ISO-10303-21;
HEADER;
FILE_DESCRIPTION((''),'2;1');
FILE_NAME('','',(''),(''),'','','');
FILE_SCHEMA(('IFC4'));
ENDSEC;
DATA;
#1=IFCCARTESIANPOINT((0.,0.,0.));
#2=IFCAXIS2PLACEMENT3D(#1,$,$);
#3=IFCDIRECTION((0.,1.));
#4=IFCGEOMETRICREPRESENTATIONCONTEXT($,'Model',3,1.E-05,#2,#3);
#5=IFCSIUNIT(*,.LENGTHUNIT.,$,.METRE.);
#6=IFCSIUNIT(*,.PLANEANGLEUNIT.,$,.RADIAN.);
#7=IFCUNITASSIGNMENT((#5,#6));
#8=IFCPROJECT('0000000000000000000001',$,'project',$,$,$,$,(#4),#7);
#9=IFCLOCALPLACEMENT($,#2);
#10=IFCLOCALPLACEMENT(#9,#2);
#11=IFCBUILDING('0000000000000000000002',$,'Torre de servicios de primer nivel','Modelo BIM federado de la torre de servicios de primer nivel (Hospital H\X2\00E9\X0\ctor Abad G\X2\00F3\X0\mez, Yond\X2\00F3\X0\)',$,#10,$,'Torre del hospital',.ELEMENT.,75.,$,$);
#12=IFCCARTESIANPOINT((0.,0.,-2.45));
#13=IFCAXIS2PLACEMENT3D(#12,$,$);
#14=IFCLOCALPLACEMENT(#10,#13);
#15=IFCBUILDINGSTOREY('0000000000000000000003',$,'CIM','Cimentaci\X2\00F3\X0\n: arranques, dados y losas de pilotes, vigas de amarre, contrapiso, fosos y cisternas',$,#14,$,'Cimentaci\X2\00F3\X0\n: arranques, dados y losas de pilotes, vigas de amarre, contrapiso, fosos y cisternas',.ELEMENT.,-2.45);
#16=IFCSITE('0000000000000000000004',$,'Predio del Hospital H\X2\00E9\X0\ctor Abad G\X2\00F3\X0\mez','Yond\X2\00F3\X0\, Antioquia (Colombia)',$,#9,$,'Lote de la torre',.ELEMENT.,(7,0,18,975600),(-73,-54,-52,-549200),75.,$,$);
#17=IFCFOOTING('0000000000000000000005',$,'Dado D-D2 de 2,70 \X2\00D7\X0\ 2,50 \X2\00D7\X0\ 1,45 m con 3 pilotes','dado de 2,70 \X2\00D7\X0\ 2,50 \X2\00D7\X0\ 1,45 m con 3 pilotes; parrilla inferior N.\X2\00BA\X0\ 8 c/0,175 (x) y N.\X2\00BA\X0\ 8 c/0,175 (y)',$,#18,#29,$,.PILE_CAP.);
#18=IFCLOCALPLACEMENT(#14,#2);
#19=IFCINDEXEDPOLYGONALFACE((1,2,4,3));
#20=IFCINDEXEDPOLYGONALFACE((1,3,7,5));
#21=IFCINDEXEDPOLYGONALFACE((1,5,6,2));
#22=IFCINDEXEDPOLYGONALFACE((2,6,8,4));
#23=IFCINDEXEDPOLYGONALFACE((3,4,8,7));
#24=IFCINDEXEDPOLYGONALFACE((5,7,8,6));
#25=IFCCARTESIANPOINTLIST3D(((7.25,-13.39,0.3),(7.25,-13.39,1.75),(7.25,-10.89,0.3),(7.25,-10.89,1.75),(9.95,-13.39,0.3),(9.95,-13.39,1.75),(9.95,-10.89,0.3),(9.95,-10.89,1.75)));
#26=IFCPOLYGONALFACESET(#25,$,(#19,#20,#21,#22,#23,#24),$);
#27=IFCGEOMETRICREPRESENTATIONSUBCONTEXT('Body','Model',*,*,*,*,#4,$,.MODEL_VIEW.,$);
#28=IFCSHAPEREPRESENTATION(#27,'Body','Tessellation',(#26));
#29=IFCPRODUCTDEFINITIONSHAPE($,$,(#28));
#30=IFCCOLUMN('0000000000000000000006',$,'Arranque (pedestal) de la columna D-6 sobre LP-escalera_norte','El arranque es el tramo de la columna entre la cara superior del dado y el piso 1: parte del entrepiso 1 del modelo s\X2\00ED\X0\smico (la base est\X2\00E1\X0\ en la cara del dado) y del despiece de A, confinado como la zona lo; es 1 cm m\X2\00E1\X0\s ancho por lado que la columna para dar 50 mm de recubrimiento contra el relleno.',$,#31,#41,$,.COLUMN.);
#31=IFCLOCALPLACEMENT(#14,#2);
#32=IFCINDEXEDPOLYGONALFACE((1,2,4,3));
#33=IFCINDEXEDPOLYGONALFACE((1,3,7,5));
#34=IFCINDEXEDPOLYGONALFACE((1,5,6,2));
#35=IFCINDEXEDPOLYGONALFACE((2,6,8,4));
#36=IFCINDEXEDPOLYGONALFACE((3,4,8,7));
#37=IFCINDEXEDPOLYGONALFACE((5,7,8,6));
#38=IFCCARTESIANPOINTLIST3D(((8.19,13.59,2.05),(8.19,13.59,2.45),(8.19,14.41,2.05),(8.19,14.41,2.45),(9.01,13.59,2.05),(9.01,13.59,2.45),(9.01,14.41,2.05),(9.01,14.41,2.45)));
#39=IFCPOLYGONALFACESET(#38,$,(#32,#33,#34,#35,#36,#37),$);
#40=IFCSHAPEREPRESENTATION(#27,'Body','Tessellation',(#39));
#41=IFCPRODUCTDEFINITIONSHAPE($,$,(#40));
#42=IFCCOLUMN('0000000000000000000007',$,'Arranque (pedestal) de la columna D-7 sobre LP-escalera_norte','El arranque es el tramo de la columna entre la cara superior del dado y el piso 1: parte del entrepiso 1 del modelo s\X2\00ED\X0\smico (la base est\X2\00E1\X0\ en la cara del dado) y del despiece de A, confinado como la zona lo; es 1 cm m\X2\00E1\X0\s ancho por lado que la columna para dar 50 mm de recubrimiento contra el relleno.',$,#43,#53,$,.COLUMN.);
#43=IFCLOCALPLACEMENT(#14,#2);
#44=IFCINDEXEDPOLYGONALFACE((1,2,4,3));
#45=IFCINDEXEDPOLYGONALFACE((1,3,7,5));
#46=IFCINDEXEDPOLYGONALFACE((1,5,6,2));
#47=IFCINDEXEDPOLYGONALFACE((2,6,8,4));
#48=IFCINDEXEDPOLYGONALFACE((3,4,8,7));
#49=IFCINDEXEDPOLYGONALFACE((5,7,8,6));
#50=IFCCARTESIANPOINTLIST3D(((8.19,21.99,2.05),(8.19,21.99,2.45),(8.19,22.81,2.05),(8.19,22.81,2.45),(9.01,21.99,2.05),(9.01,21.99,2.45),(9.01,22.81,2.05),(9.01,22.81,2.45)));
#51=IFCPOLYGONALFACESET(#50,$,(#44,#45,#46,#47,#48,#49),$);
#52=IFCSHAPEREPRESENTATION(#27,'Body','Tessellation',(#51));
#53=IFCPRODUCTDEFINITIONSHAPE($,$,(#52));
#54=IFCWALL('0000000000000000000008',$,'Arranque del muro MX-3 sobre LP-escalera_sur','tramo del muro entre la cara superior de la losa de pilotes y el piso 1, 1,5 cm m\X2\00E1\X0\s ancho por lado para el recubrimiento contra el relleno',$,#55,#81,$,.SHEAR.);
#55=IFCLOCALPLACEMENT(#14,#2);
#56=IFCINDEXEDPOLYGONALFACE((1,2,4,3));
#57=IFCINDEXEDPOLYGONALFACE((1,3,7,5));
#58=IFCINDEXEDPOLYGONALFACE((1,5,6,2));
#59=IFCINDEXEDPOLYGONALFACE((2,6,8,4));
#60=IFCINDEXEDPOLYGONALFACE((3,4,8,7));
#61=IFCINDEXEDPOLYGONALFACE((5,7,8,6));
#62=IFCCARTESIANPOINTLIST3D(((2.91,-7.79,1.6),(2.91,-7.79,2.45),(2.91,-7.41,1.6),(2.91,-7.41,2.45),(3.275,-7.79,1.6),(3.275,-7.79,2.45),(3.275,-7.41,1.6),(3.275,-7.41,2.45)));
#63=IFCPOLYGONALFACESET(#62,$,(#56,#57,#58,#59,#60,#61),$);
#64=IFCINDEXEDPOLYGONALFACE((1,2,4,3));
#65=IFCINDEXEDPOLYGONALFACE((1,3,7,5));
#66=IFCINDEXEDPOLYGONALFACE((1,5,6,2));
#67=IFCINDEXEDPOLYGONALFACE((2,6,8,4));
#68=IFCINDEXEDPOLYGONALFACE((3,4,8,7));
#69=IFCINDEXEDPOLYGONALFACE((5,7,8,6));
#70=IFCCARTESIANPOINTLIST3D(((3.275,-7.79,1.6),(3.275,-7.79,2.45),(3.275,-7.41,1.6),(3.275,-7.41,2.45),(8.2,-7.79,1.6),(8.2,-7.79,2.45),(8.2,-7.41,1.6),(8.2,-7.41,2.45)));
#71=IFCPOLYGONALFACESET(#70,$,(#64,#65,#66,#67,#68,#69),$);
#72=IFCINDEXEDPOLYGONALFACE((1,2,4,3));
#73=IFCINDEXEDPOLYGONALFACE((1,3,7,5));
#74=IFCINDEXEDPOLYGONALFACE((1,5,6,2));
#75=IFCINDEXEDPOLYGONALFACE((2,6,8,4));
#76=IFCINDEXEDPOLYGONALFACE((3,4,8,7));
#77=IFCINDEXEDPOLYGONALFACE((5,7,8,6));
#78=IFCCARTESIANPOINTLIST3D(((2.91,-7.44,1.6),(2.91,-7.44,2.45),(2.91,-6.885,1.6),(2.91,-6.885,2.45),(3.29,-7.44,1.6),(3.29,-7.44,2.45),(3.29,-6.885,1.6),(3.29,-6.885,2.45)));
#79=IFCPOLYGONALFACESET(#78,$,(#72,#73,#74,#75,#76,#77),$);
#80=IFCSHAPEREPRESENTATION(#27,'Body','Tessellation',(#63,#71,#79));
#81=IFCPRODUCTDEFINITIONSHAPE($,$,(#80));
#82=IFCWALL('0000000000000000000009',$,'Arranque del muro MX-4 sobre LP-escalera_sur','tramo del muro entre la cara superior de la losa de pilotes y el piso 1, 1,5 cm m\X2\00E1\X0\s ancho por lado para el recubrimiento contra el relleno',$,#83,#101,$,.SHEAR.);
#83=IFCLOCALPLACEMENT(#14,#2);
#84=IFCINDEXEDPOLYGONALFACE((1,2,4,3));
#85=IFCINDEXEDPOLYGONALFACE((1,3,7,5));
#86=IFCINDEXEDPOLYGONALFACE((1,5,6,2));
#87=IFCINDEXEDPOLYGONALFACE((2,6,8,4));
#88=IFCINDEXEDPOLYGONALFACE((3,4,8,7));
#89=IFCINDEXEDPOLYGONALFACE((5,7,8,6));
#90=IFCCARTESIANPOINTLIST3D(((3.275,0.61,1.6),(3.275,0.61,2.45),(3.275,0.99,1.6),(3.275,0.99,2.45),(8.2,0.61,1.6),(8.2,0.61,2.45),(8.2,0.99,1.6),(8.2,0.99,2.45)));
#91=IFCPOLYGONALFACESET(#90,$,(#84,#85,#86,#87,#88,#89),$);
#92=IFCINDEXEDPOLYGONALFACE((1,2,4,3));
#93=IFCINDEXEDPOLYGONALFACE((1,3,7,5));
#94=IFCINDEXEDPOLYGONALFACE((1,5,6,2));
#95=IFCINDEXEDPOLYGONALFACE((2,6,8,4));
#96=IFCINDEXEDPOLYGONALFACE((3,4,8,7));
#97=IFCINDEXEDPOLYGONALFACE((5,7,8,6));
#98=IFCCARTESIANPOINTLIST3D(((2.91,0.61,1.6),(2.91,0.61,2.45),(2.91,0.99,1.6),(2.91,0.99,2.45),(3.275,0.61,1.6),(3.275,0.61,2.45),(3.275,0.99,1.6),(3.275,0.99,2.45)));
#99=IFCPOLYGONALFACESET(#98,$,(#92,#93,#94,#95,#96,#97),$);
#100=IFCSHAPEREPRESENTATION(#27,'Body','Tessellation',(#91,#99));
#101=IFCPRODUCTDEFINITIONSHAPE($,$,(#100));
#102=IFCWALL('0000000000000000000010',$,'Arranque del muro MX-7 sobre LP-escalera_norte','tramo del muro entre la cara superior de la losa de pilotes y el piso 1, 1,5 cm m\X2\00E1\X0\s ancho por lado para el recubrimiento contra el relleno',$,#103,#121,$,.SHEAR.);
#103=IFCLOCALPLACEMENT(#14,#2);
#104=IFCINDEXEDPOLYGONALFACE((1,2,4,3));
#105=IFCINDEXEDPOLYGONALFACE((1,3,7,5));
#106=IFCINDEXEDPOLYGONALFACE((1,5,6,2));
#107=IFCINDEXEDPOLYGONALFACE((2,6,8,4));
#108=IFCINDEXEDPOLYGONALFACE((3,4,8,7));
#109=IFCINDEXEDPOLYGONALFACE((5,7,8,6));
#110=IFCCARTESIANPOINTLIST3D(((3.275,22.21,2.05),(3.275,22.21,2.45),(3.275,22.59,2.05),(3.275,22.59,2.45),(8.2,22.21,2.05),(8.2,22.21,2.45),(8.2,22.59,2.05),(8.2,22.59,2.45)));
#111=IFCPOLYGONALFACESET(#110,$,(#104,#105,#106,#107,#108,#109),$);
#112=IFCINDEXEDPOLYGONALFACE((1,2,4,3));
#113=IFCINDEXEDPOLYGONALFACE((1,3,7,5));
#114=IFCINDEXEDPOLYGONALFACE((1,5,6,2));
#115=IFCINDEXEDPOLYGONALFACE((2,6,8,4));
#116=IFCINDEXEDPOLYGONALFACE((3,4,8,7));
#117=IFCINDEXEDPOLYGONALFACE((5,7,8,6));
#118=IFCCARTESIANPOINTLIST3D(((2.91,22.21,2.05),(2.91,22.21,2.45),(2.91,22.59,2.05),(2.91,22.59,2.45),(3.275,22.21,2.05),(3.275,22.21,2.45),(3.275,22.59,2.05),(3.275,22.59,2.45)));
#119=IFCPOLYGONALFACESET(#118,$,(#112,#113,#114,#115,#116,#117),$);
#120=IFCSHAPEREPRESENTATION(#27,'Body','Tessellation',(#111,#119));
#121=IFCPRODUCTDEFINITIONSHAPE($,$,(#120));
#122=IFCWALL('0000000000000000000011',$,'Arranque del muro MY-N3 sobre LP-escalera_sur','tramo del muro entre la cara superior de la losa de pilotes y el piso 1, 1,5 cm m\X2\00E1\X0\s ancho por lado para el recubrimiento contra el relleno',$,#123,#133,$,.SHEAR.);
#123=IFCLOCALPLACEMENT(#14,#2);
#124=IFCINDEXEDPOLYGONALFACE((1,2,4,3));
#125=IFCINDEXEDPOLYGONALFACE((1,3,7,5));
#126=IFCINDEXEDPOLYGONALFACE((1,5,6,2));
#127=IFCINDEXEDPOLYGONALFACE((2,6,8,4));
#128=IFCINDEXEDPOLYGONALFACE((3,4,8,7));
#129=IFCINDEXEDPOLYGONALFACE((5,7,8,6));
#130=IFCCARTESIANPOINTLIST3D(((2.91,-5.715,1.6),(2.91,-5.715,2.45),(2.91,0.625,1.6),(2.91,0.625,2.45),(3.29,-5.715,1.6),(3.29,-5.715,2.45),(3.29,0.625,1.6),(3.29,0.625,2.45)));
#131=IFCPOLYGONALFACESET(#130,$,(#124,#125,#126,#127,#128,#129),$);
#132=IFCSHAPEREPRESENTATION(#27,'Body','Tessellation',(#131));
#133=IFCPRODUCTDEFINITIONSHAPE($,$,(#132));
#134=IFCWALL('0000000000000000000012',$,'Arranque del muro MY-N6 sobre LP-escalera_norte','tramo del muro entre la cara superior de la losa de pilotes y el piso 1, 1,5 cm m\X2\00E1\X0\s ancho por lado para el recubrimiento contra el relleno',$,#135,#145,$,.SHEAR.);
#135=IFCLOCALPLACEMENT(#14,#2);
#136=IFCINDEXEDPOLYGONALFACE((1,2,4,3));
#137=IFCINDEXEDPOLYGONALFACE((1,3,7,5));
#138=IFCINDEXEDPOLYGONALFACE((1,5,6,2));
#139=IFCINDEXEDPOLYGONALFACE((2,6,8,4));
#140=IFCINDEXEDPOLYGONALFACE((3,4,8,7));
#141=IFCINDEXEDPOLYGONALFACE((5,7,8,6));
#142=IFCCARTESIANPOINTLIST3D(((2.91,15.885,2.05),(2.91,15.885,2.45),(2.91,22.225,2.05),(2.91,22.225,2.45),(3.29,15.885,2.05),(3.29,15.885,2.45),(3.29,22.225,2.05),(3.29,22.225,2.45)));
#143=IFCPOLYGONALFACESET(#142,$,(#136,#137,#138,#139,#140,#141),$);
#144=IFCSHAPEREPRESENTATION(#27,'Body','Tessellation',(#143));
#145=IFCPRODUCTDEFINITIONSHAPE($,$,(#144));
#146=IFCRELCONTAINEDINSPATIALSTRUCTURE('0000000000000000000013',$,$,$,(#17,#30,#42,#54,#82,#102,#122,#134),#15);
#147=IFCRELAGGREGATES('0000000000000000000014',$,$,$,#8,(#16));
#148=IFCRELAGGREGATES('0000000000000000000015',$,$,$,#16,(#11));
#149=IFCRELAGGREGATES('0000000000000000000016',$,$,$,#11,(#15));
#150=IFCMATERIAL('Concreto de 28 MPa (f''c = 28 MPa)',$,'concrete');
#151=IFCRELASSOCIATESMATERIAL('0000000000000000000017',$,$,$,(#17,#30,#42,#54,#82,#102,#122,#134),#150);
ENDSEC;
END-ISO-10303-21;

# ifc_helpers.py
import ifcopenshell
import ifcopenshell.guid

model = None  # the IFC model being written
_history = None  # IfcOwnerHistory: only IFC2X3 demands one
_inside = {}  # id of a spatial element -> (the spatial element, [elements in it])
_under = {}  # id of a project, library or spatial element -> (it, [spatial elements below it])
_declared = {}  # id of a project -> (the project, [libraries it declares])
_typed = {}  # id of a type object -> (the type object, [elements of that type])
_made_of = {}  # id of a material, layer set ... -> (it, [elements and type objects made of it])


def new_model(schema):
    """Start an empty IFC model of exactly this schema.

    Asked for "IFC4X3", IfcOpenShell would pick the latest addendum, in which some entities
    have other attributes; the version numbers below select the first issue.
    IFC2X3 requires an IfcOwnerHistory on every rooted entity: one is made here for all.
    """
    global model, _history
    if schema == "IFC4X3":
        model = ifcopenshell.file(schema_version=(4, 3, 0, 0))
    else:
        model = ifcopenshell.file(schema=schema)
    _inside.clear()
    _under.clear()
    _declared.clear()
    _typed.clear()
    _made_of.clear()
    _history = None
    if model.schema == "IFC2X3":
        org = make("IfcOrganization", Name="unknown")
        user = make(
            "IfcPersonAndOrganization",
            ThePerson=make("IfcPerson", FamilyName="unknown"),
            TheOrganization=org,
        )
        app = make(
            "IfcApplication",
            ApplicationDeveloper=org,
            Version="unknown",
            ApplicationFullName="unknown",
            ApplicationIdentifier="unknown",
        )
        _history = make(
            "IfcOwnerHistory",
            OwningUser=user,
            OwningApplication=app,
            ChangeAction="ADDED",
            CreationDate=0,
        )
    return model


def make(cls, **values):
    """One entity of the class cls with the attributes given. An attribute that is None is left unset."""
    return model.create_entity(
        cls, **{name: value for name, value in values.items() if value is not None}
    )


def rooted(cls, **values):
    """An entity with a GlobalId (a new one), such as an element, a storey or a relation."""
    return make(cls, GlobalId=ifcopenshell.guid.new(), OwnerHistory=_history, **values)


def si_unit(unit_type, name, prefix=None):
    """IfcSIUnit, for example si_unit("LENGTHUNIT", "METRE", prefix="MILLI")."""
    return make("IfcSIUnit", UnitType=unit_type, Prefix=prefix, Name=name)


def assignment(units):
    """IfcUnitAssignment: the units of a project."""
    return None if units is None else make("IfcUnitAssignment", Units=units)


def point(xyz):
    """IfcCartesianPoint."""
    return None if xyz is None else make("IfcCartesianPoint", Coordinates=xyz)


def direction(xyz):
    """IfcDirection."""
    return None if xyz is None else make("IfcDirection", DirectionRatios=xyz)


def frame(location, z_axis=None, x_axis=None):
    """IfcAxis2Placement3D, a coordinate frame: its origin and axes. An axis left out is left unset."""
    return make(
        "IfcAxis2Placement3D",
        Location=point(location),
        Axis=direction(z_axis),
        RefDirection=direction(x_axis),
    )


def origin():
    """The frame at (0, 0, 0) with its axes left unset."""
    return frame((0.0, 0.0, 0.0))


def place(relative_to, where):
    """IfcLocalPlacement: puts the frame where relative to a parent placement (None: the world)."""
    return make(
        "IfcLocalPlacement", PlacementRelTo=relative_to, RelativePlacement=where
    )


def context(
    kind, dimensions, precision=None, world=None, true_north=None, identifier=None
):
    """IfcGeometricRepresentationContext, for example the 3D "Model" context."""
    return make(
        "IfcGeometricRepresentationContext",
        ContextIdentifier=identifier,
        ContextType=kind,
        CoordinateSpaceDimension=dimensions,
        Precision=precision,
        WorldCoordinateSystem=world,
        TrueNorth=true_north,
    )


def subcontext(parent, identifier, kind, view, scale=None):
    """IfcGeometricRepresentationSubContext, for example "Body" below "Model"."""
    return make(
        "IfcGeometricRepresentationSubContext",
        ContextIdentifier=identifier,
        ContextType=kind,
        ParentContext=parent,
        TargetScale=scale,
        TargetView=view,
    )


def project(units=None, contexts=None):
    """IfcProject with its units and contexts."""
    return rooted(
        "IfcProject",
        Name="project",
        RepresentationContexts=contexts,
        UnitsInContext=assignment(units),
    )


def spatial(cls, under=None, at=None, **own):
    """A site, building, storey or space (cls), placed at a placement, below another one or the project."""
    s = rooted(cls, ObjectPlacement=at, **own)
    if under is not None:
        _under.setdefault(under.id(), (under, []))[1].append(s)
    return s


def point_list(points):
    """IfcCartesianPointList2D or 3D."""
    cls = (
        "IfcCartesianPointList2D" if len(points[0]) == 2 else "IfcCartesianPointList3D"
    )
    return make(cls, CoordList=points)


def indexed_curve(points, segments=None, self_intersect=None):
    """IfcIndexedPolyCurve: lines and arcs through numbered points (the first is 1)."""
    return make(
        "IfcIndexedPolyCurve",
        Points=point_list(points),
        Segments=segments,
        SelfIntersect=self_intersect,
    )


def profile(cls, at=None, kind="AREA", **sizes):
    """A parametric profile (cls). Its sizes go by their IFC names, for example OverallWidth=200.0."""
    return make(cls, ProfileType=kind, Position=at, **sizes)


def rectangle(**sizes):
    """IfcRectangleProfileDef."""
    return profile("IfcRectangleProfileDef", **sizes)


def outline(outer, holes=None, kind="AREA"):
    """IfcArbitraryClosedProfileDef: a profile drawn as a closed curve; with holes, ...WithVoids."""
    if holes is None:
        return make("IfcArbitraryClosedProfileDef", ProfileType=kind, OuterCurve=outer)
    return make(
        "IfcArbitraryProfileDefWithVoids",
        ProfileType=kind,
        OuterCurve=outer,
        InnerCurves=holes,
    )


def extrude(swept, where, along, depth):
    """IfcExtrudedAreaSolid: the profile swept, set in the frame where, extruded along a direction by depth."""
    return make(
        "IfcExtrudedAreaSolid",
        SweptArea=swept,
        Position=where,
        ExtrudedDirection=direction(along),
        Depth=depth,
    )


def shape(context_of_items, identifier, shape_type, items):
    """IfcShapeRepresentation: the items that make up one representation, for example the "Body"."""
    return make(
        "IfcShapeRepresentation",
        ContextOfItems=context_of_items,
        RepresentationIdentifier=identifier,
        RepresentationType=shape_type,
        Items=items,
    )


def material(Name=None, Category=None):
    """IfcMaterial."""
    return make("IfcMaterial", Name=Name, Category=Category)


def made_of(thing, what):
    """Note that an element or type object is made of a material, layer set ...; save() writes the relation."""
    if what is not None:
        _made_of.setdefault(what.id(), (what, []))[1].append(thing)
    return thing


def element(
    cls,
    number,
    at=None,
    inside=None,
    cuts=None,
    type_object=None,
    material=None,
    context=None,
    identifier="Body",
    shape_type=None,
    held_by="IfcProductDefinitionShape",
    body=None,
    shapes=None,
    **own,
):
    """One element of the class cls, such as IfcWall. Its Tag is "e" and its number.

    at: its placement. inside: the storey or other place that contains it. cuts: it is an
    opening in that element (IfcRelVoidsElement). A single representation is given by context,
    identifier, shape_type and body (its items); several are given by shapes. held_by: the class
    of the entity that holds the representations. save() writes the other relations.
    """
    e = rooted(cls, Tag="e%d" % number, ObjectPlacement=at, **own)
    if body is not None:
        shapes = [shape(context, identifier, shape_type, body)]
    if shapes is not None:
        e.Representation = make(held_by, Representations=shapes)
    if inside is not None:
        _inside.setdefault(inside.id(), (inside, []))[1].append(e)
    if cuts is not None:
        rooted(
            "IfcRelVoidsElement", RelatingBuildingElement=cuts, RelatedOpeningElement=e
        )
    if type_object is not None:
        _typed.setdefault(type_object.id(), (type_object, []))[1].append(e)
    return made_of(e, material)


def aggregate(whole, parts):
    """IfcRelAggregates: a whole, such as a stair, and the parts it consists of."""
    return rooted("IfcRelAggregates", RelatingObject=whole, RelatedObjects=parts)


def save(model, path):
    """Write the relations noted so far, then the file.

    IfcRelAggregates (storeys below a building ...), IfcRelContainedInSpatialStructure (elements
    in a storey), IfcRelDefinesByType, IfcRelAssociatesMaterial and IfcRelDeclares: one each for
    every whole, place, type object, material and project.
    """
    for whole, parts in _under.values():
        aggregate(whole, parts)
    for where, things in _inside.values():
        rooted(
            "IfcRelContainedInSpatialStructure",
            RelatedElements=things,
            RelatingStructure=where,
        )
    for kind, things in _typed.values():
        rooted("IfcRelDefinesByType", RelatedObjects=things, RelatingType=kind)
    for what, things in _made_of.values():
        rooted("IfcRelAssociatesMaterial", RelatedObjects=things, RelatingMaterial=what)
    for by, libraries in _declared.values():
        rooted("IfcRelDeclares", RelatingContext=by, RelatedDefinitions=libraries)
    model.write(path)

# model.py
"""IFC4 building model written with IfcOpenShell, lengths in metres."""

from ifc_helpers import new_model, si_unit, direction, frame, origin, place, context, subcontext, project, spatial, indexed_curve, rectangle, outline, extrude, material, element, save


model = new_model("IFC4")

# Units and contexts
model_context = context("Model", 3, precision=1e-05, world=origin(), true_north=direction((0.0, 1.0)))
body_context = subcontext(model_context, "Body", "Model", "MODEL_VIEW")
ifc_project = project(units=[si_unit("LENGTHUNIT", "METRE"), si_unit("PLANEANGLEUNIT", "RADIAN")], contexts=[model_context])

# Site, building, storey
site_placement = place(None, origin())
site = spatial("IfcSite", under=ifc_project, at=site_placement, Name="Predio del Hospital Héctor Abad Gómez", Description="Yondó, Antioquia (Colombia)", LongName="Lote de la torre", CompositionType="ELEMENT", RefLatitude=(7, 0, 18, 975600), RefLongitude=(-73, -54, -52, -549200), RefElevation=75.0)
building_placement = place(site_placement, origin())
building = spatial("IfcBuilding", under=site, at=building_placement, Name="Torre de servicios de primer nivel", Description="Modelo BIM federado de la torre de servicios de primer nivel (Hospital Héctor Abad Gómez, Yondó)", LongName="Torre del hospital", CompositionType="ELEMENT", ElevationOfRefHeight=75.0)
placement = place(building_placement, frame((0.0, 0.0, -2.45)))
storey = spatial("IfcBuildingStorey", under=building, at=placement, Name="CIM", Description="Cimentación: arranques, dados y losas de pilotes, vigas de amarre, contrapiso, fosos y cisternas", LongName="Cimentación: arranques, dados y losas de pilotes, vigas de amarre, contrapiso, fosos y cisternas", CompositionType="ELEMENT", Elevation=-2.45)

# Footing
ifc_material = material(Name="Concreto de 28 MPa (f'c = 28 MPa)", Category="concrete")
element("IfcFooting", 1, at=placement, inside=storey, material=ifc_material, Name="Dado D-D2 de 2,70 × 2,50 × 1,45 m con 3 pilotes", Description="dado de 2,70 × 2,50 × 1,45 m con 3 pilotes; parrilla inferior N.º 8 c/0,175 (x) y N.º 8 c/0,175 (y)", PredefinedType="PILE_CAP", context=body_context, shape_type="SweptSolid", body=[
    extrude(rectangle(XDim=2.7, YDim=2.5), frame((8.6, -12.14, 0.3)), (0.0, 0.0, 1.0), 1.45),
])

# Columns
element("IfcColumn", 2, at=placement, inside=storey, material=ifc_material, Name="Arranque (pedestal) de la columna D-6 sobre LP-escalera_norte", Description="El arranque es el tramo de la columna entre la cara superior del dado y el piso 1: parte del entrepiso 1 del modelo sísmico (la base está en la cara del dado) y del despiece de A, confinado como la zona lo; es 1 cm más ancho por lado que la columna para dar 50 mm de recubrimiento contra el relleno.", PredefinedType="COLUMN", context=body_context, shape_type="SweptSolid", body=[
    extrude(rectangle(XDim=0.82, YDim=0.82), frame((8.6, 14.0, 2.05)), (0.0, 0.0, 1.0), 0.4),
])
element("IfcColumn", 3, at=placement, inside=storey, material=ifc_material, Name="Arranque (pedestal) de la columna D-7 sobre LP-escalera_norte", Description="El arranque es el tramo de la columna entre la cara superior del dado y el piso 1: parte del entrepiso 1 del modelo sísmico (la base está en la cara del dado) y del despiece de A, confinado como la zona lo; es 1 cm más ancho por lado que la columna para dar 50 mm de recubrimiento contra el relleno.", PredefinedType="COLUMN", context=body_context, shape_type="SweptSolid", body=[
    extrude(rectangle(XDim=0.82, YDim=0.82), frame((8.6, 22.4, 2.05)), (0.0, 0.0, 1.0), 0.4),
])

# Walls
element("IfcWall", 4, at=placement, inside=storey, material=ifc_material, Name="Arranque del muro MX-3 sobre LP-escalera_sur", Description="tramo del muro entre la cara superior de la losa de pilotes y el piso 1, 1,5 cm más ancho por lado para el recubrimiento contra el relleno", PredefinedType="SHEAR", context=body_context, shape_type="SweptSolid", body=[
    extrude(outline(indexed_curve([(2.91, -7.79), (3.275, -7.79), (3.275, -7.41), (2.91, -7.41), (2.91, -7.79)], self_intersect=False)), frame((0.0, 0.0, 1.6)), (0.0, 0.0, 1.0), 0.85),
    extrude(outline(indexed_curve([(3.275, -7.79), (8.2, -7.79), (8.2, -7.41), (3.275, -7.41), (3.275, -7.79)], self_intersect=False)), frame((0.0, 0.0, 1.6)), (0.0, 0.0, 1.0), 0.85),
    extrude(outline(indexed_curve([(2.91, -7.44), (3.29, -7.44), (3.29, -6.885), (2.91, -6.885), (2.91, -7.44)], self_intersect=False)), frame((0.0, 0.0, 1.6)), (0.0, 0.0, 1.0), 0.85),
])
element("IfcWall", 5, at=placement, inside=storey, material=ifc_material, Name="Arranque del muro MX-4 sobre LP-escalera_sur", Description="tramo del muro entre la cara superior de la losa de pilotes y el piso 1, 1,5 cm más ancho por lado para el recubrimiento contra el relleno", PredefinedType="SHEAR", context=body_context, shape_type="SweptSolid", body=[
    extrude(outline(indexed_curve([(3.275, 0.61), (8.2, 0.61), (8.2, 0.99), (3.275, 0.99), (3.275, 0.61)], self_intersect=False)), frame((0.0, 0.0, 1.6)), (0.0, 0.0, 1.0), 0.85),
    extrude(outline(indexed_curve([(2.91, 0.61), (3.275, 0.61), (3.275, 0.99), (2.91, 0.99), (2.91, 0.61)], self_intersect=False)), frame((0.0, 0.0, 1.6)), (0.0, 0.0, 1.0), 0.85),
])
element("IfcWall", 6, at=placement, inside=storey, material=ifc_material, Name="Arranque del muro MX-7 sobre LP-escalera_norte", Description="tramo del muro entre la cara superior de la losa de pilotes y el piso 1, 1,5 cm más ancho por lado para el recubrimiento contra el relleno", PredefinedType="SHEAR", context=body_context, shape_type="SweptSolid", body=[
    extrude(outline(indexed_curve([(3.275, 22.21), (8.2, 22.21), (8.2, 22.59), (3.275, 22.59), (3.275, 22.21)], self_intersect=False)), frame((0.0, 0.0, 2.05)), (0.0, 0.0, 1.0), 0.4),
    extrude(outline(indexed_curve([(2.91, 22.21), (3.275, 22.21), (3.275, 22.59), (2.91, 22.59), (2.91, 22.21)], self_intersect=False)), frame((0.0, 0.0, 2.05)), (0.0, 0.0, 1.0), 0.4),
])
element("IfcWall", 7, at=placement, inside=storey, material=ifc_material, Name="Arranque del muro MY-N3 sobre LP-escalera_sur", Description="tramo del muro entre la cara superior de la losa de pilotes y el piso 1, 1,5 cm más ancho por lado para el recubrimiento contra el relleno", PredefinedType="SHEAR", context=body_context, shape_type="SweptSolid", body=[
    extrude(outline(indexed_curve([(2.91, -5.715), (3.29, -5.715), (3.29, 0.625), (2.91, 0.625), (2.91, -5.715)], self_intersect=False)), frame((0.0, 0.0, 1.6)), (0.0, 0.0, 1.0), 0.85),
])
element("IfcWall", 8, at=placement, inside=storey, material=ifc_material, Name="Arranque del muro MY-N6 sobre LP-escalera_norte", Description="tramo del muro entre la cara superior de la losa de pilotes y el piso 1, 1,5 cm más ancho por lado para el recubrimiento contra el relleno", PredefinedType="SHEAR", context=body_context, shape_type="SweptSolid", body=[
    extrude(outline(indexed_curve([(2.91, 15.885), (3.29, 15.885), (3.29, 22.225), (2.91, 22.225), (2.91, 15.885)], self_intersect=False)), frame((0.0, 0.0, 2.05)), (0.0, 0.0, 1.0), 0.4),
])

save(model, "model.ifc")
